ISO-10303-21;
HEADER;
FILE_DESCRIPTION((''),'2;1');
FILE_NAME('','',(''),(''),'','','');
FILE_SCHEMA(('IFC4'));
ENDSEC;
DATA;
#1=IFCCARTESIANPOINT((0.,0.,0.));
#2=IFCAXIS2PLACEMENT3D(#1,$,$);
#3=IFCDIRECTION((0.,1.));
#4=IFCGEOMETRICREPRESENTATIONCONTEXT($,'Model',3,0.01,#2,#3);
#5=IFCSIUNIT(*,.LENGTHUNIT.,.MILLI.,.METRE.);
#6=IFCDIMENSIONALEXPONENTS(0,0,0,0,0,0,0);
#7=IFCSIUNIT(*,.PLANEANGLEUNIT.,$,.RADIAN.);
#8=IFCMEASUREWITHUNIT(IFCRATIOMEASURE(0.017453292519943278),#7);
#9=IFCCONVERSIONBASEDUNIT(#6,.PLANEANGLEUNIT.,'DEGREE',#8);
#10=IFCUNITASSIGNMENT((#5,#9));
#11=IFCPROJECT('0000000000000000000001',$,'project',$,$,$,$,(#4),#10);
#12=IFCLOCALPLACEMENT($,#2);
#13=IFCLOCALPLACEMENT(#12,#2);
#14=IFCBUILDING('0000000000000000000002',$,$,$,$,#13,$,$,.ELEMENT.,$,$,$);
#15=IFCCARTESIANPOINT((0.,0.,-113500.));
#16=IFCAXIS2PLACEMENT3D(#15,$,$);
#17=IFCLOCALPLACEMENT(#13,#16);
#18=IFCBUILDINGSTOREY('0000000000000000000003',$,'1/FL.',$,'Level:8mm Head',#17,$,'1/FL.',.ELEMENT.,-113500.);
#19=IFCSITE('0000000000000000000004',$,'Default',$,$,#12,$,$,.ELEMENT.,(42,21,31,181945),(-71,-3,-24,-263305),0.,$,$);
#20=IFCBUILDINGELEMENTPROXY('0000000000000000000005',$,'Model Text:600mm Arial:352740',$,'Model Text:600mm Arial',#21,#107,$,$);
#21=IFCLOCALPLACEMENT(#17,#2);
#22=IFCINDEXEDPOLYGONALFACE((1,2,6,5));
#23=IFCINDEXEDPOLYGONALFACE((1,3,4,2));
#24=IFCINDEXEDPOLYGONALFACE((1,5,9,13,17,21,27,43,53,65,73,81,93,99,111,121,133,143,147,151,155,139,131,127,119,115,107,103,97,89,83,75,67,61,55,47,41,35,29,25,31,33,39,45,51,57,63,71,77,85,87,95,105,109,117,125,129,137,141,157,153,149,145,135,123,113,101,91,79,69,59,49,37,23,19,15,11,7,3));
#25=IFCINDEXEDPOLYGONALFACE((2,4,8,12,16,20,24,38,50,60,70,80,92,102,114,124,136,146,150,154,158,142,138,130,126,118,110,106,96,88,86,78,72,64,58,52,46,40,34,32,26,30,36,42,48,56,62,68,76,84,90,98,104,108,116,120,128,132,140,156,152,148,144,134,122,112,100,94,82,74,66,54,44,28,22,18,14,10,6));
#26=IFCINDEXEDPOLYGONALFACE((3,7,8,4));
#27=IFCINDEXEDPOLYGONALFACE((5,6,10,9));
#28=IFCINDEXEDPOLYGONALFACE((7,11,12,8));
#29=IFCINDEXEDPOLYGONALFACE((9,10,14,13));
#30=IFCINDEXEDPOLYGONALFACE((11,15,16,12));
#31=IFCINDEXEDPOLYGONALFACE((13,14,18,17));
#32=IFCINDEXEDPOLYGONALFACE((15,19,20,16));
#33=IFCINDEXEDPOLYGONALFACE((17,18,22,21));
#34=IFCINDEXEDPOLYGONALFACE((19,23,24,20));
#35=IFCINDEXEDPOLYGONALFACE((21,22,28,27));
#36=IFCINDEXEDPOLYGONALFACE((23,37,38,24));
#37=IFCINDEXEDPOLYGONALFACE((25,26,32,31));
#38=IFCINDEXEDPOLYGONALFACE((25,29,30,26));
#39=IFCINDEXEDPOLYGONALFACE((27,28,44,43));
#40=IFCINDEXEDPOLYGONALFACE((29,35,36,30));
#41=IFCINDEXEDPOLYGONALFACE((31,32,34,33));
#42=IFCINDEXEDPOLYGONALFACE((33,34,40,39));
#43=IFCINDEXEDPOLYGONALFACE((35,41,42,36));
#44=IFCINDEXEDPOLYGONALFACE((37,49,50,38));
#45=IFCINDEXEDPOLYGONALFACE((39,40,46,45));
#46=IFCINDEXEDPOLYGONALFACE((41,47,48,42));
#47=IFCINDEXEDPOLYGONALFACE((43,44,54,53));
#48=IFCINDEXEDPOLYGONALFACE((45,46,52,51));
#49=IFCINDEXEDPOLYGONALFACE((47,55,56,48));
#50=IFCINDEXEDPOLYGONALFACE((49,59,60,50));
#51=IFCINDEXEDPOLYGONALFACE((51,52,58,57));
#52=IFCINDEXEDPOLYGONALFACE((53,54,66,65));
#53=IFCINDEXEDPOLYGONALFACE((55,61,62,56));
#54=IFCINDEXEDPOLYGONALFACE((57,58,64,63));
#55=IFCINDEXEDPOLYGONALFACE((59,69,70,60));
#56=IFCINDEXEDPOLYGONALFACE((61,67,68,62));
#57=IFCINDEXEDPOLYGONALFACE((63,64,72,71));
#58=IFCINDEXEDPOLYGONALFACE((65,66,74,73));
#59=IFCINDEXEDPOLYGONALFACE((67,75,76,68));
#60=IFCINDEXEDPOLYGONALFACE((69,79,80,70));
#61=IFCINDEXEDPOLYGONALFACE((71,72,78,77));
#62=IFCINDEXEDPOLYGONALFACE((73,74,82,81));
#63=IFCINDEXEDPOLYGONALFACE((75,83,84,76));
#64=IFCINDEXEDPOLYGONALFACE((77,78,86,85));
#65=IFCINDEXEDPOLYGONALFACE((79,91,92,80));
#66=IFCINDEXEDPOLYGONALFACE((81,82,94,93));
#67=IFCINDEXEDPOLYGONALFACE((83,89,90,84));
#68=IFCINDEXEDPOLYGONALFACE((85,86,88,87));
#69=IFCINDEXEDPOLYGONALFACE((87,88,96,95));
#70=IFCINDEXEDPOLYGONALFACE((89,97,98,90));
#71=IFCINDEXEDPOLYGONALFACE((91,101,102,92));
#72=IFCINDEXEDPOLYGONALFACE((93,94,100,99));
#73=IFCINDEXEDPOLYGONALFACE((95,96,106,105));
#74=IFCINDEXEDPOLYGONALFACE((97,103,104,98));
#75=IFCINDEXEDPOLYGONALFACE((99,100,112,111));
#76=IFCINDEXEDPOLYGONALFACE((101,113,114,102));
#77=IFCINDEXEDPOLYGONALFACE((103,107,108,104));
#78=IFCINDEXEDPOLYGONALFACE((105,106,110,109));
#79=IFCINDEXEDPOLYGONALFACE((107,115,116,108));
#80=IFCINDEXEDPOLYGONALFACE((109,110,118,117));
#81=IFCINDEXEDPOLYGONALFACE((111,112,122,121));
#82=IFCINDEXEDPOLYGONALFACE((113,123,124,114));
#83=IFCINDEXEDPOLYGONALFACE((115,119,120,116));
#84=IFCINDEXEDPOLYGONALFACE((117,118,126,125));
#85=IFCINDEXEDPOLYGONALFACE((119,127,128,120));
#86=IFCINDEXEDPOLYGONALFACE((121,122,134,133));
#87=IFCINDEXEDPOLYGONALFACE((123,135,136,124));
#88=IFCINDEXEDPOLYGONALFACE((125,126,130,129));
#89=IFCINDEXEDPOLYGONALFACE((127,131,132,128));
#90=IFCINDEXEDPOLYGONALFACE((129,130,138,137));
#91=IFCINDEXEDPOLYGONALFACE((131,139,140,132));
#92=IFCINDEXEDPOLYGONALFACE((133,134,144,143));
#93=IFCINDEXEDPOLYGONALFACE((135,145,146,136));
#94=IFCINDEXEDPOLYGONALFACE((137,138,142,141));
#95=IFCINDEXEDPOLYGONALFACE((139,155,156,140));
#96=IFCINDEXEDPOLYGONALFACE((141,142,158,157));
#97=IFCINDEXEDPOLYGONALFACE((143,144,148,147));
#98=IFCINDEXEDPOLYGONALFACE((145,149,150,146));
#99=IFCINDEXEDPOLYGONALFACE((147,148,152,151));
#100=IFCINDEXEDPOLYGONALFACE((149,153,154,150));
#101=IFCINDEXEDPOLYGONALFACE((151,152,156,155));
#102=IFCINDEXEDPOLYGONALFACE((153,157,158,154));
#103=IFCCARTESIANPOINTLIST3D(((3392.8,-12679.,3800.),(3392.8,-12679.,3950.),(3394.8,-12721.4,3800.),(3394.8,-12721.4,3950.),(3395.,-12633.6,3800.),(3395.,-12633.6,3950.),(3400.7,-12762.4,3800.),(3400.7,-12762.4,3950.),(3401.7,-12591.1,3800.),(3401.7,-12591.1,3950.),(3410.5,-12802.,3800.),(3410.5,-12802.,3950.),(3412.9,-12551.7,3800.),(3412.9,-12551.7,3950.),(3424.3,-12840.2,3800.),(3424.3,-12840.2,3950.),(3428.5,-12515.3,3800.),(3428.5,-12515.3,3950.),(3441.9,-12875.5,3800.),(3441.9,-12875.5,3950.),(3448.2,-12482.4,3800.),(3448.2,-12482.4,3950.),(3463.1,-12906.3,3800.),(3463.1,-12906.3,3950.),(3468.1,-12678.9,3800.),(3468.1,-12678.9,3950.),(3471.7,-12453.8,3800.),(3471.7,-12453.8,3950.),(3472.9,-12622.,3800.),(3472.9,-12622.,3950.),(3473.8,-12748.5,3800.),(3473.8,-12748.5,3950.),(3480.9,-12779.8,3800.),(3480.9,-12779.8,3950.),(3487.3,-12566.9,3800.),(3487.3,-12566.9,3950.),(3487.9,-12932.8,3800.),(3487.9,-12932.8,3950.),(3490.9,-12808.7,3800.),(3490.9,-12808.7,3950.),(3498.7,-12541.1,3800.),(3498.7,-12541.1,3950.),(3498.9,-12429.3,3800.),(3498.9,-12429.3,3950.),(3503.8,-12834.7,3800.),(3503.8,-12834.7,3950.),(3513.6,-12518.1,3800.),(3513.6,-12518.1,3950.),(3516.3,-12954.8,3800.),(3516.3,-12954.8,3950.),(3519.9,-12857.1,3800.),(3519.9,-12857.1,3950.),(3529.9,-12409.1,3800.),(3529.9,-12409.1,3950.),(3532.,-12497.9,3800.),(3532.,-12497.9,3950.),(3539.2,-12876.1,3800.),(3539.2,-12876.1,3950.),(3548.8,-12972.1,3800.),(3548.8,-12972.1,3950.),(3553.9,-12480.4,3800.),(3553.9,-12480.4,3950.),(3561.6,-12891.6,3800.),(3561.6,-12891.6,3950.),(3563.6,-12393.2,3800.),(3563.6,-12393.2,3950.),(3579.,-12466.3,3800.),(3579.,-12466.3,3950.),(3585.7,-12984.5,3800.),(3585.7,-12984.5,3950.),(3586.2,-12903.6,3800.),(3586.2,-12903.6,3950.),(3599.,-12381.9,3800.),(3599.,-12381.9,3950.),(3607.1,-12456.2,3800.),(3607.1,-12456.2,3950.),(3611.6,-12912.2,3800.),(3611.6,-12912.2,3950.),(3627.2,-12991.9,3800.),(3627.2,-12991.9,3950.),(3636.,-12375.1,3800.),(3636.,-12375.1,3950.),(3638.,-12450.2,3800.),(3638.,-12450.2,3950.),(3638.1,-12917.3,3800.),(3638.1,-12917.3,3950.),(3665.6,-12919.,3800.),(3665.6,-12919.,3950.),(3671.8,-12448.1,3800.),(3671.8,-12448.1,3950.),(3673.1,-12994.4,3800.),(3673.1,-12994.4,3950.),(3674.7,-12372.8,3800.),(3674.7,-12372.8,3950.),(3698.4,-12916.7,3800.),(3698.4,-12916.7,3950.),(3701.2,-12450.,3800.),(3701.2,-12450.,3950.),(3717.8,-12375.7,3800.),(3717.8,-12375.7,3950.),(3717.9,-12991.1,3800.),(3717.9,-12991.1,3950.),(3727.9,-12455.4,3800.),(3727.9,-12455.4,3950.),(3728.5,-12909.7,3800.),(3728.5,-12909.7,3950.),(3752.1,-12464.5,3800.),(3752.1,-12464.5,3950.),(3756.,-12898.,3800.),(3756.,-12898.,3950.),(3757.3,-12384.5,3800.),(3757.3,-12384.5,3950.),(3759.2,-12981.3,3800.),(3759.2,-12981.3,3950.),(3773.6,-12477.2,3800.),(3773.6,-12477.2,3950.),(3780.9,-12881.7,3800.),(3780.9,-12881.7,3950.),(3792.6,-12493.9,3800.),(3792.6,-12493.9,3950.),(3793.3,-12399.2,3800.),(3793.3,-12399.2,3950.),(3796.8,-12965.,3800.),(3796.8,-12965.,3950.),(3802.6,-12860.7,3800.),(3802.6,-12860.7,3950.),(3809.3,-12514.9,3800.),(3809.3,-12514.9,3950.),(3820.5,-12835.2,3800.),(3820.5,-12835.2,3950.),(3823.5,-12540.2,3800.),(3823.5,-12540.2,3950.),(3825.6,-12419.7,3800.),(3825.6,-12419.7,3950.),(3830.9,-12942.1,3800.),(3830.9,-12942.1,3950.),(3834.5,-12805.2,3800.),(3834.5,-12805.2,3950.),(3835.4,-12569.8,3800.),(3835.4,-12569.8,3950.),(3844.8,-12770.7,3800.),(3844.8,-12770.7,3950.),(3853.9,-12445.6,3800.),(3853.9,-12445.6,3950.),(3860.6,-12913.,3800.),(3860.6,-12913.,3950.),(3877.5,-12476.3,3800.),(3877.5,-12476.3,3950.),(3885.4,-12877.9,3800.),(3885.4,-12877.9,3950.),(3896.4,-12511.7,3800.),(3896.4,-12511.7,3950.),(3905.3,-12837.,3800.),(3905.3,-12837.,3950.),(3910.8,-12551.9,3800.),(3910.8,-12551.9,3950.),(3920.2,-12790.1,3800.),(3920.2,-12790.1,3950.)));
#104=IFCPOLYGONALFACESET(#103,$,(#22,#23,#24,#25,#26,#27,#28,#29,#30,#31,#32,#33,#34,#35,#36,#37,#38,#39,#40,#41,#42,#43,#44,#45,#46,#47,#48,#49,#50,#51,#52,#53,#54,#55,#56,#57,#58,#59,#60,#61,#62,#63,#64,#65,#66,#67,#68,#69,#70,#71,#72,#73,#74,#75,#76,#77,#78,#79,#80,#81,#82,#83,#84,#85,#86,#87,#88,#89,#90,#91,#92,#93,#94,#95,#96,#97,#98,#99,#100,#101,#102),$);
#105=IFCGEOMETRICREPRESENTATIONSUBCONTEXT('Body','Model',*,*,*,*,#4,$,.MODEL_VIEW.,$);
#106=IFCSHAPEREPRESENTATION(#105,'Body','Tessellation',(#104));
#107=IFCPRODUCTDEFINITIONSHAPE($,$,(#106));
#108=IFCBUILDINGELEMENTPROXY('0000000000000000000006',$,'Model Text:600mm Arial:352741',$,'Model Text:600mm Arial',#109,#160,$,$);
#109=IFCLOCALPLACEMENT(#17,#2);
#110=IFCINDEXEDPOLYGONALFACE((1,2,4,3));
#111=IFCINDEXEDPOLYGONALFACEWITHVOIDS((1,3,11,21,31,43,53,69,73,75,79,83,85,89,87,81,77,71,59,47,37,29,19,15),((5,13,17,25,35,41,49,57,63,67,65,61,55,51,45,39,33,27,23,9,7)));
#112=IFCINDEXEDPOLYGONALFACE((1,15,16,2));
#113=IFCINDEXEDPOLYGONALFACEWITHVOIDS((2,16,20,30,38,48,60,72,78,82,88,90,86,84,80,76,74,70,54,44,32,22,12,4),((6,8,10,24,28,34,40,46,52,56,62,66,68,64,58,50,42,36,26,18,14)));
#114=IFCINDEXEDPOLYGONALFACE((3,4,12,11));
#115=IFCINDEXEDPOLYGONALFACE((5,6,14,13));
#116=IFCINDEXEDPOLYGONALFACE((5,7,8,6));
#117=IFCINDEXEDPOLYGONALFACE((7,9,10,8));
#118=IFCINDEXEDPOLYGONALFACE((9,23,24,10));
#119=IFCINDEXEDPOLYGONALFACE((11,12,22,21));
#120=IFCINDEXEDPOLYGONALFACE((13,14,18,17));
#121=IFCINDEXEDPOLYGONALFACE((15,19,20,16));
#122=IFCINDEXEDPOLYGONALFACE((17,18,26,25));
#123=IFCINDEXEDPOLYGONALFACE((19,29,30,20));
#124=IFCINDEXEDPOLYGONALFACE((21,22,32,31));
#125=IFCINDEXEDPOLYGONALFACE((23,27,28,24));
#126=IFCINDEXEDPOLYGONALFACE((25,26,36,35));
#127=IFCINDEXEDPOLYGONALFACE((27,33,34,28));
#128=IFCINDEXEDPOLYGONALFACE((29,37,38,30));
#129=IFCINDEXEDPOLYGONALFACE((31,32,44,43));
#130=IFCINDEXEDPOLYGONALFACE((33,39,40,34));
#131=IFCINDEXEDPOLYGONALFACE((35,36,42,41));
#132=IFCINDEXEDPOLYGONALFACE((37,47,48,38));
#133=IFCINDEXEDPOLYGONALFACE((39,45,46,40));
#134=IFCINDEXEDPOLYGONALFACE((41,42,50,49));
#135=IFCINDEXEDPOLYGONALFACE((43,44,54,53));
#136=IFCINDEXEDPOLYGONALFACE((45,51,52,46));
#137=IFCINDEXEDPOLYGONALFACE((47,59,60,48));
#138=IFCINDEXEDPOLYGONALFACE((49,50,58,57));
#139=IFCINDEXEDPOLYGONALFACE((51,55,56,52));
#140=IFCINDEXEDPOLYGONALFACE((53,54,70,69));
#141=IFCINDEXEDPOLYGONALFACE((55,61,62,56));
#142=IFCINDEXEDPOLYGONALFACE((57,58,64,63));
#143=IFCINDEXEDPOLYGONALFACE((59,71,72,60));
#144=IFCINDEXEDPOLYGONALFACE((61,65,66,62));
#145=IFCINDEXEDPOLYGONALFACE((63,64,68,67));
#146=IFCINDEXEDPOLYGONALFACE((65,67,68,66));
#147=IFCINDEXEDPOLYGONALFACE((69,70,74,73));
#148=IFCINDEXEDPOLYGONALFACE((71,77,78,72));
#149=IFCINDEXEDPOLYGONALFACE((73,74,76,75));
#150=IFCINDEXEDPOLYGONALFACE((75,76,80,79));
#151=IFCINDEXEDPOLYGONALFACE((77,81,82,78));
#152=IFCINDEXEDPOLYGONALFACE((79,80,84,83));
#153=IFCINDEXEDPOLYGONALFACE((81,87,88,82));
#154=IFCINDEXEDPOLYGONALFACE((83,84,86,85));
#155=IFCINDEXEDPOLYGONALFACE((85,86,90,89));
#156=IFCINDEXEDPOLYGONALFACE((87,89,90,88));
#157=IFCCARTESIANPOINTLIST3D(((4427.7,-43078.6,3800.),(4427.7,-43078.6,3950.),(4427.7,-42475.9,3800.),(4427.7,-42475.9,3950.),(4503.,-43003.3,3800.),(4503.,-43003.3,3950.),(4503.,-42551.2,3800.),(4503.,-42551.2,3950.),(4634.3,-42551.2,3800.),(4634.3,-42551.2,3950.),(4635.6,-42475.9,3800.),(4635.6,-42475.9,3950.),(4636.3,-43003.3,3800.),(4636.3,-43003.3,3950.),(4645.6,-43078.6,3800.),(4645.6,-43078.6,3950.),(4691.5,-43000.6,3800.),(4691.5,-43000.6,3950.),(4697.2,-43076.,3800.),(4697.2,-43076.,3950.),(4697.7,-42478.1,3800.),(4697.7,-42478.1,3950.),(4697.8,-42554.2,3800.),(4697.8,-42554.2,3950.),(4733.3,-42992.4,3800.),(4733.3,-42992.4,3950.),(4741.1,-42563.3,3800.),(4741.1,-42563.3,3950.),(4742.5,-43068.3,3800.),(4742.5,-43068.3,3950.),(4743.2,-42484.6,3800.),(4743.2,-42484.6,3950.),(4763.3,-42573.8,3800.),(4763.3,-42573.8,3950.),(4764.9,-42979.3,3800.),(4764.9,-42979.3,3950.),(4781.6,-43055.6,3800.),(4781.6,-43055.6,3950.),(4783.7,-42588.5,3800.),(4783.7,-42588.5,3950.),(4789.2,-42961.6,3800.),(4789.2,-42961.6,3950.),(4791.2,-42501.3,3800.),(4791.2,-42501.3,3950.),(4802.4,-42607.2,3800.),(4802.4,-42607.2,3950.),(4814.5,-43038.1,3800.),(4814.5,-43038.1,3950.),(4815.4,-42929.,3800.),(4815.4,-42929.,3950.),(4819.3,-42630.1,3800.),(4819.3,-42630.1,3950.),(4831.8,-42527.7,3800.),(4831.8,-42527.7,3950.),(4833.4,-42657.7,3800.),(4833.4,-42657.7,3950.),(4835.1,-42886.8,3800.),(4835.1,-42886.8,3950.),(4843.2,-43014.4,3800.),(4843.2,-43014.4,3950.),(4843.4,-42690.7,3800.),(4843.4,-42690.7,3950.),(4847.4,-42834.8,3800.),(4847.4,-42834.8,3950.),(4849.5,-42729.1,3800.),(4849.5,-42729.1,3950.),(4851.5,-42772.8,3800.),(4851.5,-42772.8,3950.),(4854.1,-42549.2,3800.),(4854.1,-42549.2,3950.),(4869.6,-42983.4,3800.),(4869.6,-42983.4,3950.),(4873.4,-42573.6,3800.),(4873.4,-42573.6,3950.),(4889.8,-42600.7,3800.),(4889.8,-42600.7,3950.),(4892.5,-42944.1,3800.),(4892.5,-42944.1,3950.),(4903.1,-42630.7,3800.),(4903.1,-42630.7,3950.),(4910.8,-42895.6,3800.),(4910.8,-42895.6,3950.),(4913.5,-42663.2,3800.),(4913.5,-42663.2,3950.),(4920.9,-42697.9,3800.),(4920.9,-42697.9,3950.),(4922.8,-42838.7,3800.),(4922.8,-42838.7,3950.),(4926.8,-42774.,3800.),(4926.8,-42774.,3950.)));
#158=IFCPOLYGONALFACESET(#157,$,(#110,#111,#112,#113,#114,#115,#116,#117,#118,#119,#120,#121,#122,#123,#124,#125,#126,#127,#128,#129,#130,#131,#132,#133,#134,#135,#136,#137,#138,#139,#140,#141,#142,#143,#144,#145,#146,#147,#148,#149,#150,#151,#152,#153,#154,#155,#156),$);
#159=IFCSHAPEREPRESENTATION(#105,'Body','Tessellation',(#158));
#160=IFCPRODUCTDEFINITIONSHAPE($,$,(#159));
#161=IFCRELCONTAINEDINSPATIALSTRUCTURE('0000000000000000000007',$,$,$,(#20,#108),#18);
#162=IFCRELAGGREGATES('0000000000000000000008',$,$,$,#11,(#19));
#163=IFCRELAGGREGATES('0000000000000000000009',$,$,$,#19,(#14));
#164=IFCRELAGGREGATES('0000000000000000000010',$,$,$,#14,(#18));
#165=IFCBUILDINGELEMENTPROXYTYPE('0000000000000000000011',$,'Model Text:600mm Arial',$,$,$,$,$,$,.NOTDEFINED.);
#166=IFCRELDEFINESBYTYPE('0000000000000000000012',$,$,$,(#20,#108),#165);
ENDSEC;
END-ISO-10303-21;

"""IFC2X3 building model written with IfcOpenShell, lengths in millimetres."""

from ifc_helpers import new_model, entity, si_unit, converted_unit, direction, frame, origin, place, context, subcontext, project, spatial, polyline, outline, extrude, type_object, element, save


model = new_model("IFC2X3")

# Units and contexts
model_context = context("Model", 3, precision=0.01, world=origin(), true_north=direction((0.0, 1.0)))
body_context = subcontext(model_context, "Body", "Model", "MODEL_VIEW")
ifc_project = project(units=[si_unit("LENGTHUNIT", "METRE", prefix="MILLI"), converted_unit("PLANEANGLEUNIT", "DEGREE", entity("IfcRatioMeasure", 0.017453292519943278), si_unit("PLANEANGLEUNIT", "RADIAN"), dimensions=[0, 0, 0, 0, 0, 0, 0])], contexts=[model_context])

# Site, building, storey
site_placement = place(None, origin())
site = spatial("IfcSite", under=ifc_project, at=site_placement, Name="Default", CompositionType="ELEMENT", RefLatitude=(42, 21, 31, 181945), RefLongitude=(-71, -3, -24, -263305), RefElevation=0.0)
building_placement = place(site_placement, origin())
building = spatial("IfcBuilding", under=site, at=building_placement, CompositionType="ELEMENT")
storey_placement = place(building_placement, frame((0.0, 0.0, -113500.0)))
storey = spatial("IfcBuildingStorey", under=building, at=storey_placement, Name="1/FL.", ObjectType="Level:8mm Head", LongName="1/FL.", CompositionType="ELEMENT", Elevation=-113500.0)

# Building element proxies
building_element_proxy_type = type_object("IfcBuildingElementProxyType", Name="Model Text:600mm Arial", PredefinedType="NOTDEFINED")
proxy_1_placement = place(storey_placement, origin())
element("IfcBuildingElementProxy", 1, at=proxy_1_placement, inside=storey, type_object=building_element_proxy_type, Name="Model Text:600mm Arial:352740", ObjectType="Model Text:600mm Arial", context=body_context, shape_type="SweptSolid", body=[
    extrude(outline(polyline([(25.5, -224.6), (22.6, -302.4), (71.8, -301.5), (116.7, -294.1), (157.3, -280.3), (193.7, -260.1), (225.4, -234.1), (251.8, -202.7), (273.0, -165.9), (288.9, -123.9), (299.7, -79.2), (304.4, -37.3), (303.1, 1.6), (295.7, 37.7), (282.8, 71.2), (264.5, 102.5), (241.0, 131.6), (212.2, 158.5), (179.5, 182.7), (144.3, 203.4), (106.8, 220.8), (66.7, 234.8), (22.6, 245.6), (-20.0, 251.3), (-61.0, 251.9), (-100.4, 247.4), (-137.5, 237.8), (-171.7, 223.5), (-202.9, 204.4), (-231.1, 180.4), (-256.0, 152.7), (-276.9, 122.0), (-294.0, 88.5), (-307.2, 52.0), (-316.7, 9.9), (-319.6, -30.5), (-315.8, -69.1), (-305.3, -106.0), (-288.6, -140.4), (-266.0, -171.8), (-237.5, -200.1), (-203.0, -225.3), (-164.3, -158.2), (-189.3, -138.4), (-209.5, -117.5), (-224.9, -95.6), (-235.4, -72.5), (-241.5, -48.3), (-243.3, -22.5), (-240.8, 4.7), (-234.2, 33.3), (-222.6, 65.2), (-208.0, 93.1), (-190.3, 117.0), (-169.7, 137.1), (-146.6, 153.1), (-122.0, 165.0), (-95.7, 172.7), (-67.7, 176.2), (-10.8, 174.3), (45.1, 162.6), (110.2, 137.3), (138.1, 121.6), (163.0, 103.8), (184.2, 84.0), (201.1, 62.1), (213.8, 38.2), (222.2, 12.3), (226.7, -14.6), (227.7, -41.5), (225.1, -68.4), (218.9, -95.2), (207.3, -125.9), (191.9, -152.8), (172.9, -175.8), (150.1, -195.0), (123.8, -209.8), (94.3, -219.7), (61.5, -224.6), (25.5, -224.6)])), frame((3636.9, -12682.1, 3800.0), z_axis=(0.0, 0.0, -1.0), x_axis=(-0.285544, -0.958366, 0.0)), (0.0, 0.0, -1.0), 150.0),
])
proxy_2_placement = place(storey_placement, origin())
element("IfcBuildingElementProxy", 2, at=proxy_2_placement, inside=storey, type_object=building_element_proxy_type, Name="Model Text:600mm Arial:352741", ObjectType="Model Text:600mm Arial", context=body_context, shape_type="SweptSolid", body=[
    extrude(outline(polyline([(-362.2, -307.6), (-144.3, -307.6), (-92.7, -305.0), (-47.4, -297.3), (-8.3, -284.6), (24.7, -267.1), (53.4, -243.4), (79.7, -212.4), (102.6, -173.1), (120.9, -124.6), (132.9, -67.7), (137.0, -3.0), (131.0, 73.1), (123.6, 107.9), (113.3, 140.3), (99.9, 170.3), (83.6, 197.4), (64.2, 221.8), (41.9, 243.3), (1.4, 269.7), (-46.7, 286.4), (-92.1, 293.0), (-154.3, 295.1), (-362.2, 295.1), (-362.2, -307.6)]), holes=[polyline([(-286.8, -232.3), (-286.8, 219.8), (-155.6, 219.8), (-92.1, 216.8), (-48.8, 207.7), (-26.6, 197.2), (-6.2, 182.6), (12.5, 163.8), (29.5, 140.9), (43.5, 113.3), (53.6, 80.3), (59.6, 41.9), (61.6, -1.8), (57.5, -63.8), (45.2, -115.8), (25.5, -158.0), (-0.6, -190.6), (-25.0, -208.2), (-56.6, -221.4), (-98.4, -229.5), (-153.5, -232.3), (-286.8, -232.3)])]), frame((4789.9, -42771.0, 3800.0)), (0.0, 0.0, 1.0), 150.0),
])

save(model, "model.ifc")
